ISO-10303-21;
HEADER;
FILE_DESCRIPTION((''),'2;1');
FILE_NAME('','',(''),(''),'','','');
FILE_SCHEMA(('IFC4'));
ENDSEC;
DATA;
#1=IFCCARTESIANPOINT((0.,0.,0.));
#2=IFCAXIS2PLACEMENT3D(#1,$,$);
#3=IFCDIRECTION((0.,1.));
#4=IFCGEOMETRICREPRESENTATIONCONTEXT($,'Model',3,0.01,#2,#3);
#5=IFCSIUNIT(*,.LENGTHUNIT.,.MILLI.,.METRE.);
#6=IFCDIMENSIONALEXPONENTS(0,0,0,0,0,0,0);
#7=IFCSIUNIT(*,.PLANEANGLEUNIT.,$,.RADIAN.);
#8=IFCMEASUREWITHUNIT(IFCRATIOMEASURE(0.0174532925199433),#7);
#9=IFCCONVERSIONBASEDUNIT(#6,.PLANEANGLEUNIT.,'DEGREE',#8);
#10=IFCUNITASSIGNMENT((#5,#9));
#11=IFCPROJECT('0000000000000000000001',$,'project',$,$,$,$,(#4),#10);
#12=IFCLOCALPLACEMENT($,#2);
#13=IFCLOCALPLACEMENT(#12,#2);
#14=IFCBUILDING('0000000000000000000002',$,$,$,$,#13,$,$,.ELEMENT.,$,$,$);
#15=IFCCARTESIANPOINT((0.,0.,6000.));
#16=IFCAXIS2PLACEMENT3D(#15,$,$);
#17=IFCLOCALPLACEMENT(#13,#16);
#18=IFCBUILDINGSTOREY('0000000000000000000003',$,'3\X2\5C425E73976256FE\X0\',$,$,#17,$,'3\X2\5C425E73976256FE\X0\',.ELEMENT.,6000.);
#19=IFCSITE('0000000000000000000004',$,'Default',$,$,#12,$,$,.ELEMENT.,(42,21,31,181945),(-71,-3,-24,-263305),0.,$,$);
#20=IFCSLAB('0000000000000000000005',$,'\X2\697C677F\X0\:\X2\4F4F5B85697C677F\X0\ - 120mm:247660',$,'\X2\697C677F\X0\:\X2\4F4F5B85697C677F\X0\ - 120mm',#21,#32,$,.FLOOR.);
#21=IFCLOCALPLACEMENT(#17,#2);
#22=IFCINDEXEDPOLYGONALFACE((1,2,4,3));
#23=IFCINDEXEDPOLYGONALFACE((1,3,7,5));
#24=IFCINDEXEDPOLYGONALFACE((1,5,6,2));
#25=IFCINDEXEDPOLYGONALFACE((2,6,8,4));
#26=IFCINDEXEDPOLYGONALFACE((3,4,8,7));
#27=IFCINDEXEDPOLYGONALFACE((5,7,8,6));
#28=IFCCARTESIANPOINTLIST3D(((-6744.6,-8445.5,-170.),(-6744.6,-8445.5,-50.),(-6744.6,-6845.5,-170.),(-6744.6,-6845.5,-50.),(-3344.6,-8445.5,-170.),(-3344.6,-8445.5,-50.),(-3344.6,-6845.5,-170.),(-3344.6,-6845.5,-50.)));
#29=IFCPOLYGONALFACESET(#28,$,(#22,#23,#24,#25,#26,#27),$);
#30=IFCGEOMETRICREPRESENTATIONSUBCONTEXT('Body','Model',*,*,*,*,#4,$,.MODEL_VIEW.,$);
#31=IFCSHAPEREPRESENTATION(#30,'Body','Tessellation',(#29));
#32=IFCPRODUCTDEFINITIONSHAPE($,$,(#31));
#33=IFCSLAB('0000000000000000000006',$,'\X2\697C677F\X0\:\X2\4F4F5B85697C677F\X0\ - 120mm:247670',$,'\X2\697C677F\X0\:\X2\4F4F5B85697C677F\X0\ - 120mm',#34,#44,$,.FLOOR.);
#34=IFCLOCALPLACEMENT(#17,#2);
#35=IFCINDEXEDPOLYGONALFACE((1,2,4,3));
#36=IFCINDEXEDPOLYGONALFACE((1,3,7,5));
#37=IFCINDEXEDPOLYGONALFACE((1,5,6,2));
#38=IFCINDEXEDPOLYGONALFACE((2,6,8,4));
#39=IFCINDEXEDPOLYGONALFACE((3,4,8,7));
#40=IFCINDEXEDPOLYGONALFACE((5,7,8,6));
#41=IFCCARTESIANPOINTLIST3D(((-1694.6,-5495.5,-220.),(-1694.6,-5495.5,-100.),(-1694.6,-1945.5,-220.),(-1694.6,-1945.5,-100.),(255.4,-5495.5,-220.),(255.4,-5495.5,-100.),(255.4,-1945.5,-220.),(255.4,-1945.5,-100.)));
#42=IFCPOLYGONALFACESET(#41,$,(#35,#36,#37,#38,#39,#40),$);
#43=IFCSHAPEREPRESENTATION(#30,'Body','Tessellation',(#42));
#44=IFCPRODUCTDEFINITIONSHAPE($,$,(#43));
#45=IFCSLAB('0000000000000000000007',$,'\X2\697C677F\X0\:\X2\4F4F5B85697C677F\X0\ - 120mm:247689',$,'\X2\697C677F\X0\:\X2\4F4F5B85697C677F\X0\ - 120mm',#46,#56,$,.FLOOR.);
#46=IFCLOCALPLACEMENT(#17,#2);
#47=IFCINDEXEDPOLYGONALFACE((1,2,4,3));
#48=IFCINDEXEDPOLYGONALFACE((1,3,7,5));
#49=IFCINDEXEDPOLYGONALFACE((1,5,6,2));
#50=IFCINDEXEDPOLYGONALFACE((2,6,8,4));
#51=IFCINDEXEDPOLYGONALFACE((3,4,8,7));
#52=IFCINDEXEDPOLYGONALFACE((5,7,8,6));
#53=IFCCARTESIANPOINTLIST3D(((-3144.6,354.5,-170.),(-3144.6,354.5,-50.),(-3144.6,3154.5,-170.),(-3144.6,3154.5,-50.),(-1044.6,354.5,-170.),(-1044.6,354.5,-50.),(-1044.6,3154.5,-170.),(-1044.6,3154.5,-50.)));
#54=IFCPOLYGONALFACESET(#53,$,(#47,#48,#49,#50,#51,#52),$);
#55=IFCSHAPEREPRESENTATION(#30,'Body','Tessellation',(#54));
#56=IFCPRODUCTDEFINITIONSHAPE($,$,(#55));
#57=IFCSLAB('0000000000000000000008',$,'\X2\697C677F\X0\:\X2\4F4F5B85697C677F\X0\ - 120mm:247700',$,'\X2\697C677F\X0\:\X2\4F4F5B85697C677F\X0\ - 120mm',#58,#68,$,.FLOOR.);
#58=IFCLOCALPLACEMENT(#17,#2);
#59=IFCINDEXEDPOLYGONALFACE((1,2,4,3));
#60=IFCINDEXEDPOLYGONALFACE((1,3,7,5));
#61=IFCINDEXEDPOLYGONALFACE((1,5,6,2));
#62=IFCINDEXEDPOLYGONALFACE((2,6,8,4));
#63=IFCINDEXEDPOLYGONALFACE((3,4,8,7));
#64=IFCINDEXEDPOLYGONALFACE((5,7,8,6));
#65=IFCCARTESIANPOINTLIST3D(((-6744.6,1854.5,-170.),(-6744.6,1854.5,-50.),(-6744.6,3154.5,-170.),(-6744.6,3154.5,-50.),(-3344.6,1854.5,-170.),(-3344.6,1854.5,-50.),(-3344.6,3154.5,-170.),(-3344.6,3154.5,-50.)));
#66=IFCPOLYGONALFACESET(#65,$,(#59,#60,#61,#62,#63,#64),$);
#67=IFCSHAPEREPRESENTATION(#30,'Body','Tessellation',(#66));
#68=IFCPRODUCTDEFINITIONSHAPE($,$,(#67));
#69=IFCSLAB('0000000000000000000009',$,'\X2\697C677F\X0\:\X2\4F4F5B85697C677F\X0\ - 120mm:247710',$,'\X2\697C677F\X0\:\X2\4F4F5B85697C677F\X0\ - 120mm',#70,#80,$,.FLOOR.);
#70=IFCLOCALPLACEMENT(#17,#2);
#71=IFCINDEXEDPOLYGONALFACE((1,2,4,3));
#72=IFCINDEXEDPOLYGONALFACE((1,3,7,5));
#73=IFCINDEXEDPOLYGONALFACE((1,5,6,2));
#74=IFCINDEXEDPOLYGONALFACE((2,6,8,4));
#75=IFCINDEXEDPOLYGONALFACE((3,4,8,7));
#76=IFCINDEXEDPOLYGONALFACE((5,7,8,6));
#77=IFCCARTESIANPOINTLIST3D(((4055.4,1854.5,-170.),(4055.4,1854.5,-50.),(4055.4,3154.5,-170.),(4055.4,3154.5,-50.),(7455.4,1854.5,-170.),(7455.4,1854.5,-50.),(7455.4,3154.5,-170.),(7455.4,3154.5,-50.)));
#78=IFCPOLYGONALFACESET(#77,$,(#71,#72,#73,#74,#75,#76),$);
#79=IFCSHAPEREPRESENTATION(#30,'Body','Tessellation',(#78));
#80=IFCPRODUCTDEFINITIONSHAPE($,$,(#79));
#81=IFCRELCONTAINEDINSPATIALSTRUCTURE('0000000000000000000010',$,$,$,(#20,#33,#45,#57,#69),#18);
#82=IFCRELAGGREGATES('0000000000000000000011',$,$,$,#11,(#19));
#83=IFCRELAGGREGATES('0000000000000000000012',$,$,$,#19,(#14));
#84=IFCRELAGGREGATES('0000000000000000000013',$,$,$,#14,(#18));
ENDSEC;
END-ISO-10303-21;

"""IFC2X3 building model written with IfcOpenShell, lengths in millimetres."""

from ifc_helpers import new_model, entity, si_unit, converted_unit, direction, frame, frame_2d, origin, origin_2d_with_axis, place, context, subcontext, project, spatial, rectangle, extrude, element, save


model = new_model("IFC2X3")

# Units and contexts
model_context = context("Model", 3, precision=0.01, world=origin(), true_north=direction((0.0, 1.0)))
body_context = subcontext(model_context, "Body", "Model", "MODEL_VIEW")
ifc_project = project(units=[si_unit("LENGTHUNIT", "METRE", prefix="MILLI"), converted_unit("PLANEANGLEUNIT", "DEGREE", entity("IfcRatioMeasure", 0.0174532925199433), si_unit("PLANEANGLEUNIT", "RADIAN"), dimensions=[0, 0, 0, 0, 0, 0, 0])], contexts=[model_context])

# Site, building, storey
site_placement = place(None, origin())
site = spatial("IfcSite", under=ifc_project, at=site_placement, Name="Default", CompositionType="ELEMENT", RefLatitude=(42, 21, 31, 181945), RefLongitude=(-71, -3, -24, -263305), RefElevation=0.0)
building_placement = place(site_placement, origin())
building = spatial("IfcBuilding", under=site, at=building_placement, CompositionType="ELEMENT")
storey_placement = place(building_placement, frame((0.0, 0.0, 6000.0)))
storey = spatial("IfcBuildingStorey", under=building, at=storey_placement, Name="3层平面图", LongName="3层平面图", CompositionType="ELEMENT", Elevation=6000.0)

# Slabs
slab_1_placement = place(storey_placement, origin())
element("IfcSlab", 1, at=slab_1_placement, inside=storey, Name="楼板:住宅楼板 - 120mm:247660", ObjectType="楼板:住宅楼板 - 120mm", PredefinedType="FLOOR", context=body_context, shape_type="SweptSolid", body=[
    extrude(rectangle(XDim=1600.0, YDim=3400.0, at=frame_2d((0.0, 0.0), x_axis=(1.0, 0.0))), frame((-5044.6, -7645.5, -50.0), z_axis=(0.0, 0.0, -1.0), x_axis=(0.0, 1.0, 0.0)), (0.0, 0.0, 1.0), 120.0),
])
slab_2_placement = place(storey_placement, frame((-1694.6, -5495.5, -220.0)))
element("IfcSlab", 2, at=slab_2_placement, inside=storey, Name="楼板:住宅楼板 - 120mm:247670", ObjectType="楼板:住宅楼板 - 120mm", PredefinedType="FLOOR", context=body_context, shape_type="SweptSolid", body=[
    extrude(rectangle(XDim=3550.0, YDim=1950.0, at=frame_2d((1075.0, 0.0), x_axis=(0.0, -1.0))), frame((2050.0, 1775.0, 120.0), z_axis=(0.0, 0.0, -1.0), x_axis=(-1.0, 0.0, 0.0)), (0.0, 0.0, 1.0), 120.0),
])
slab_3_placement = place(storey_placement, origin())
element("IfcSlab", 3, at=slab_3_placement, inside=storey, Name="楼板:住宅楼板 - 120mm:247689", ObjectType="楼板:住宅楼板 - 120mm", PredefinedType="FLOOR", context=body_context, shape_type="SweptSolid", body=[
    extrude(rectangle(XDim=2800.0, YDim=2100.0, at=origin_2d_with_axis()), frame((-2094.6, 1754.5, -50.0), z_axis=(0.0, 0.0, -1.0), x_axis=(0.0, 1.0, 0.0)), (0.0, 0.0, 1.0), 120.0),
])
slab_4_placement = place(storey_placement, origin())
element("IfcSlab", 4, at=slab_4_placement, inside=storey, Name="楼板:住宅楼板 - 120mm:247700", ObjectType="楼板:住宅楼板 - 120mm", PredefinedType="FLOOR", context=body_context, shape_type="SweptSolid", body=[
    extrude(rectangle(XDim=1300.0, YDim=3400.0, at=frame_2d((0.0, 0.0), x_axis=(1.0, 0.0))), frame((-5044.6, 2504.5, -50.0), z_axis=(0.0, 0.0, -1.0), x_axis=(0.0, 1.0, 0.0)), (0.0, 0.0, 1.0), 120.0),
])
slab_5_placement = place(storey_placement, origin())
element("IfcSlab", 5, at=slab_5_placement, inside=storey, Name="楼板:住宅楼板 - 120mm:247710", ObjectType="楼板:住宅楼板 - 120mm", PredefinedType="FLOOR", context=body_context, shape_type="SweptSolid", body=[
    extrude(rectangle(XDim=1300.0, YDim=3400.0, at=frame_2d((0.0, 0.0), x_axis=(1.0, 0.0))), frame((5755.4, 2504.5, -50.0), z_axis=(0.0, 0.0, -1.0), x_axis=(0.0, 1.0, 0.0)), (0.0, 0.0, 1.0), 120.0),
])

save(model, "model.ifc")
